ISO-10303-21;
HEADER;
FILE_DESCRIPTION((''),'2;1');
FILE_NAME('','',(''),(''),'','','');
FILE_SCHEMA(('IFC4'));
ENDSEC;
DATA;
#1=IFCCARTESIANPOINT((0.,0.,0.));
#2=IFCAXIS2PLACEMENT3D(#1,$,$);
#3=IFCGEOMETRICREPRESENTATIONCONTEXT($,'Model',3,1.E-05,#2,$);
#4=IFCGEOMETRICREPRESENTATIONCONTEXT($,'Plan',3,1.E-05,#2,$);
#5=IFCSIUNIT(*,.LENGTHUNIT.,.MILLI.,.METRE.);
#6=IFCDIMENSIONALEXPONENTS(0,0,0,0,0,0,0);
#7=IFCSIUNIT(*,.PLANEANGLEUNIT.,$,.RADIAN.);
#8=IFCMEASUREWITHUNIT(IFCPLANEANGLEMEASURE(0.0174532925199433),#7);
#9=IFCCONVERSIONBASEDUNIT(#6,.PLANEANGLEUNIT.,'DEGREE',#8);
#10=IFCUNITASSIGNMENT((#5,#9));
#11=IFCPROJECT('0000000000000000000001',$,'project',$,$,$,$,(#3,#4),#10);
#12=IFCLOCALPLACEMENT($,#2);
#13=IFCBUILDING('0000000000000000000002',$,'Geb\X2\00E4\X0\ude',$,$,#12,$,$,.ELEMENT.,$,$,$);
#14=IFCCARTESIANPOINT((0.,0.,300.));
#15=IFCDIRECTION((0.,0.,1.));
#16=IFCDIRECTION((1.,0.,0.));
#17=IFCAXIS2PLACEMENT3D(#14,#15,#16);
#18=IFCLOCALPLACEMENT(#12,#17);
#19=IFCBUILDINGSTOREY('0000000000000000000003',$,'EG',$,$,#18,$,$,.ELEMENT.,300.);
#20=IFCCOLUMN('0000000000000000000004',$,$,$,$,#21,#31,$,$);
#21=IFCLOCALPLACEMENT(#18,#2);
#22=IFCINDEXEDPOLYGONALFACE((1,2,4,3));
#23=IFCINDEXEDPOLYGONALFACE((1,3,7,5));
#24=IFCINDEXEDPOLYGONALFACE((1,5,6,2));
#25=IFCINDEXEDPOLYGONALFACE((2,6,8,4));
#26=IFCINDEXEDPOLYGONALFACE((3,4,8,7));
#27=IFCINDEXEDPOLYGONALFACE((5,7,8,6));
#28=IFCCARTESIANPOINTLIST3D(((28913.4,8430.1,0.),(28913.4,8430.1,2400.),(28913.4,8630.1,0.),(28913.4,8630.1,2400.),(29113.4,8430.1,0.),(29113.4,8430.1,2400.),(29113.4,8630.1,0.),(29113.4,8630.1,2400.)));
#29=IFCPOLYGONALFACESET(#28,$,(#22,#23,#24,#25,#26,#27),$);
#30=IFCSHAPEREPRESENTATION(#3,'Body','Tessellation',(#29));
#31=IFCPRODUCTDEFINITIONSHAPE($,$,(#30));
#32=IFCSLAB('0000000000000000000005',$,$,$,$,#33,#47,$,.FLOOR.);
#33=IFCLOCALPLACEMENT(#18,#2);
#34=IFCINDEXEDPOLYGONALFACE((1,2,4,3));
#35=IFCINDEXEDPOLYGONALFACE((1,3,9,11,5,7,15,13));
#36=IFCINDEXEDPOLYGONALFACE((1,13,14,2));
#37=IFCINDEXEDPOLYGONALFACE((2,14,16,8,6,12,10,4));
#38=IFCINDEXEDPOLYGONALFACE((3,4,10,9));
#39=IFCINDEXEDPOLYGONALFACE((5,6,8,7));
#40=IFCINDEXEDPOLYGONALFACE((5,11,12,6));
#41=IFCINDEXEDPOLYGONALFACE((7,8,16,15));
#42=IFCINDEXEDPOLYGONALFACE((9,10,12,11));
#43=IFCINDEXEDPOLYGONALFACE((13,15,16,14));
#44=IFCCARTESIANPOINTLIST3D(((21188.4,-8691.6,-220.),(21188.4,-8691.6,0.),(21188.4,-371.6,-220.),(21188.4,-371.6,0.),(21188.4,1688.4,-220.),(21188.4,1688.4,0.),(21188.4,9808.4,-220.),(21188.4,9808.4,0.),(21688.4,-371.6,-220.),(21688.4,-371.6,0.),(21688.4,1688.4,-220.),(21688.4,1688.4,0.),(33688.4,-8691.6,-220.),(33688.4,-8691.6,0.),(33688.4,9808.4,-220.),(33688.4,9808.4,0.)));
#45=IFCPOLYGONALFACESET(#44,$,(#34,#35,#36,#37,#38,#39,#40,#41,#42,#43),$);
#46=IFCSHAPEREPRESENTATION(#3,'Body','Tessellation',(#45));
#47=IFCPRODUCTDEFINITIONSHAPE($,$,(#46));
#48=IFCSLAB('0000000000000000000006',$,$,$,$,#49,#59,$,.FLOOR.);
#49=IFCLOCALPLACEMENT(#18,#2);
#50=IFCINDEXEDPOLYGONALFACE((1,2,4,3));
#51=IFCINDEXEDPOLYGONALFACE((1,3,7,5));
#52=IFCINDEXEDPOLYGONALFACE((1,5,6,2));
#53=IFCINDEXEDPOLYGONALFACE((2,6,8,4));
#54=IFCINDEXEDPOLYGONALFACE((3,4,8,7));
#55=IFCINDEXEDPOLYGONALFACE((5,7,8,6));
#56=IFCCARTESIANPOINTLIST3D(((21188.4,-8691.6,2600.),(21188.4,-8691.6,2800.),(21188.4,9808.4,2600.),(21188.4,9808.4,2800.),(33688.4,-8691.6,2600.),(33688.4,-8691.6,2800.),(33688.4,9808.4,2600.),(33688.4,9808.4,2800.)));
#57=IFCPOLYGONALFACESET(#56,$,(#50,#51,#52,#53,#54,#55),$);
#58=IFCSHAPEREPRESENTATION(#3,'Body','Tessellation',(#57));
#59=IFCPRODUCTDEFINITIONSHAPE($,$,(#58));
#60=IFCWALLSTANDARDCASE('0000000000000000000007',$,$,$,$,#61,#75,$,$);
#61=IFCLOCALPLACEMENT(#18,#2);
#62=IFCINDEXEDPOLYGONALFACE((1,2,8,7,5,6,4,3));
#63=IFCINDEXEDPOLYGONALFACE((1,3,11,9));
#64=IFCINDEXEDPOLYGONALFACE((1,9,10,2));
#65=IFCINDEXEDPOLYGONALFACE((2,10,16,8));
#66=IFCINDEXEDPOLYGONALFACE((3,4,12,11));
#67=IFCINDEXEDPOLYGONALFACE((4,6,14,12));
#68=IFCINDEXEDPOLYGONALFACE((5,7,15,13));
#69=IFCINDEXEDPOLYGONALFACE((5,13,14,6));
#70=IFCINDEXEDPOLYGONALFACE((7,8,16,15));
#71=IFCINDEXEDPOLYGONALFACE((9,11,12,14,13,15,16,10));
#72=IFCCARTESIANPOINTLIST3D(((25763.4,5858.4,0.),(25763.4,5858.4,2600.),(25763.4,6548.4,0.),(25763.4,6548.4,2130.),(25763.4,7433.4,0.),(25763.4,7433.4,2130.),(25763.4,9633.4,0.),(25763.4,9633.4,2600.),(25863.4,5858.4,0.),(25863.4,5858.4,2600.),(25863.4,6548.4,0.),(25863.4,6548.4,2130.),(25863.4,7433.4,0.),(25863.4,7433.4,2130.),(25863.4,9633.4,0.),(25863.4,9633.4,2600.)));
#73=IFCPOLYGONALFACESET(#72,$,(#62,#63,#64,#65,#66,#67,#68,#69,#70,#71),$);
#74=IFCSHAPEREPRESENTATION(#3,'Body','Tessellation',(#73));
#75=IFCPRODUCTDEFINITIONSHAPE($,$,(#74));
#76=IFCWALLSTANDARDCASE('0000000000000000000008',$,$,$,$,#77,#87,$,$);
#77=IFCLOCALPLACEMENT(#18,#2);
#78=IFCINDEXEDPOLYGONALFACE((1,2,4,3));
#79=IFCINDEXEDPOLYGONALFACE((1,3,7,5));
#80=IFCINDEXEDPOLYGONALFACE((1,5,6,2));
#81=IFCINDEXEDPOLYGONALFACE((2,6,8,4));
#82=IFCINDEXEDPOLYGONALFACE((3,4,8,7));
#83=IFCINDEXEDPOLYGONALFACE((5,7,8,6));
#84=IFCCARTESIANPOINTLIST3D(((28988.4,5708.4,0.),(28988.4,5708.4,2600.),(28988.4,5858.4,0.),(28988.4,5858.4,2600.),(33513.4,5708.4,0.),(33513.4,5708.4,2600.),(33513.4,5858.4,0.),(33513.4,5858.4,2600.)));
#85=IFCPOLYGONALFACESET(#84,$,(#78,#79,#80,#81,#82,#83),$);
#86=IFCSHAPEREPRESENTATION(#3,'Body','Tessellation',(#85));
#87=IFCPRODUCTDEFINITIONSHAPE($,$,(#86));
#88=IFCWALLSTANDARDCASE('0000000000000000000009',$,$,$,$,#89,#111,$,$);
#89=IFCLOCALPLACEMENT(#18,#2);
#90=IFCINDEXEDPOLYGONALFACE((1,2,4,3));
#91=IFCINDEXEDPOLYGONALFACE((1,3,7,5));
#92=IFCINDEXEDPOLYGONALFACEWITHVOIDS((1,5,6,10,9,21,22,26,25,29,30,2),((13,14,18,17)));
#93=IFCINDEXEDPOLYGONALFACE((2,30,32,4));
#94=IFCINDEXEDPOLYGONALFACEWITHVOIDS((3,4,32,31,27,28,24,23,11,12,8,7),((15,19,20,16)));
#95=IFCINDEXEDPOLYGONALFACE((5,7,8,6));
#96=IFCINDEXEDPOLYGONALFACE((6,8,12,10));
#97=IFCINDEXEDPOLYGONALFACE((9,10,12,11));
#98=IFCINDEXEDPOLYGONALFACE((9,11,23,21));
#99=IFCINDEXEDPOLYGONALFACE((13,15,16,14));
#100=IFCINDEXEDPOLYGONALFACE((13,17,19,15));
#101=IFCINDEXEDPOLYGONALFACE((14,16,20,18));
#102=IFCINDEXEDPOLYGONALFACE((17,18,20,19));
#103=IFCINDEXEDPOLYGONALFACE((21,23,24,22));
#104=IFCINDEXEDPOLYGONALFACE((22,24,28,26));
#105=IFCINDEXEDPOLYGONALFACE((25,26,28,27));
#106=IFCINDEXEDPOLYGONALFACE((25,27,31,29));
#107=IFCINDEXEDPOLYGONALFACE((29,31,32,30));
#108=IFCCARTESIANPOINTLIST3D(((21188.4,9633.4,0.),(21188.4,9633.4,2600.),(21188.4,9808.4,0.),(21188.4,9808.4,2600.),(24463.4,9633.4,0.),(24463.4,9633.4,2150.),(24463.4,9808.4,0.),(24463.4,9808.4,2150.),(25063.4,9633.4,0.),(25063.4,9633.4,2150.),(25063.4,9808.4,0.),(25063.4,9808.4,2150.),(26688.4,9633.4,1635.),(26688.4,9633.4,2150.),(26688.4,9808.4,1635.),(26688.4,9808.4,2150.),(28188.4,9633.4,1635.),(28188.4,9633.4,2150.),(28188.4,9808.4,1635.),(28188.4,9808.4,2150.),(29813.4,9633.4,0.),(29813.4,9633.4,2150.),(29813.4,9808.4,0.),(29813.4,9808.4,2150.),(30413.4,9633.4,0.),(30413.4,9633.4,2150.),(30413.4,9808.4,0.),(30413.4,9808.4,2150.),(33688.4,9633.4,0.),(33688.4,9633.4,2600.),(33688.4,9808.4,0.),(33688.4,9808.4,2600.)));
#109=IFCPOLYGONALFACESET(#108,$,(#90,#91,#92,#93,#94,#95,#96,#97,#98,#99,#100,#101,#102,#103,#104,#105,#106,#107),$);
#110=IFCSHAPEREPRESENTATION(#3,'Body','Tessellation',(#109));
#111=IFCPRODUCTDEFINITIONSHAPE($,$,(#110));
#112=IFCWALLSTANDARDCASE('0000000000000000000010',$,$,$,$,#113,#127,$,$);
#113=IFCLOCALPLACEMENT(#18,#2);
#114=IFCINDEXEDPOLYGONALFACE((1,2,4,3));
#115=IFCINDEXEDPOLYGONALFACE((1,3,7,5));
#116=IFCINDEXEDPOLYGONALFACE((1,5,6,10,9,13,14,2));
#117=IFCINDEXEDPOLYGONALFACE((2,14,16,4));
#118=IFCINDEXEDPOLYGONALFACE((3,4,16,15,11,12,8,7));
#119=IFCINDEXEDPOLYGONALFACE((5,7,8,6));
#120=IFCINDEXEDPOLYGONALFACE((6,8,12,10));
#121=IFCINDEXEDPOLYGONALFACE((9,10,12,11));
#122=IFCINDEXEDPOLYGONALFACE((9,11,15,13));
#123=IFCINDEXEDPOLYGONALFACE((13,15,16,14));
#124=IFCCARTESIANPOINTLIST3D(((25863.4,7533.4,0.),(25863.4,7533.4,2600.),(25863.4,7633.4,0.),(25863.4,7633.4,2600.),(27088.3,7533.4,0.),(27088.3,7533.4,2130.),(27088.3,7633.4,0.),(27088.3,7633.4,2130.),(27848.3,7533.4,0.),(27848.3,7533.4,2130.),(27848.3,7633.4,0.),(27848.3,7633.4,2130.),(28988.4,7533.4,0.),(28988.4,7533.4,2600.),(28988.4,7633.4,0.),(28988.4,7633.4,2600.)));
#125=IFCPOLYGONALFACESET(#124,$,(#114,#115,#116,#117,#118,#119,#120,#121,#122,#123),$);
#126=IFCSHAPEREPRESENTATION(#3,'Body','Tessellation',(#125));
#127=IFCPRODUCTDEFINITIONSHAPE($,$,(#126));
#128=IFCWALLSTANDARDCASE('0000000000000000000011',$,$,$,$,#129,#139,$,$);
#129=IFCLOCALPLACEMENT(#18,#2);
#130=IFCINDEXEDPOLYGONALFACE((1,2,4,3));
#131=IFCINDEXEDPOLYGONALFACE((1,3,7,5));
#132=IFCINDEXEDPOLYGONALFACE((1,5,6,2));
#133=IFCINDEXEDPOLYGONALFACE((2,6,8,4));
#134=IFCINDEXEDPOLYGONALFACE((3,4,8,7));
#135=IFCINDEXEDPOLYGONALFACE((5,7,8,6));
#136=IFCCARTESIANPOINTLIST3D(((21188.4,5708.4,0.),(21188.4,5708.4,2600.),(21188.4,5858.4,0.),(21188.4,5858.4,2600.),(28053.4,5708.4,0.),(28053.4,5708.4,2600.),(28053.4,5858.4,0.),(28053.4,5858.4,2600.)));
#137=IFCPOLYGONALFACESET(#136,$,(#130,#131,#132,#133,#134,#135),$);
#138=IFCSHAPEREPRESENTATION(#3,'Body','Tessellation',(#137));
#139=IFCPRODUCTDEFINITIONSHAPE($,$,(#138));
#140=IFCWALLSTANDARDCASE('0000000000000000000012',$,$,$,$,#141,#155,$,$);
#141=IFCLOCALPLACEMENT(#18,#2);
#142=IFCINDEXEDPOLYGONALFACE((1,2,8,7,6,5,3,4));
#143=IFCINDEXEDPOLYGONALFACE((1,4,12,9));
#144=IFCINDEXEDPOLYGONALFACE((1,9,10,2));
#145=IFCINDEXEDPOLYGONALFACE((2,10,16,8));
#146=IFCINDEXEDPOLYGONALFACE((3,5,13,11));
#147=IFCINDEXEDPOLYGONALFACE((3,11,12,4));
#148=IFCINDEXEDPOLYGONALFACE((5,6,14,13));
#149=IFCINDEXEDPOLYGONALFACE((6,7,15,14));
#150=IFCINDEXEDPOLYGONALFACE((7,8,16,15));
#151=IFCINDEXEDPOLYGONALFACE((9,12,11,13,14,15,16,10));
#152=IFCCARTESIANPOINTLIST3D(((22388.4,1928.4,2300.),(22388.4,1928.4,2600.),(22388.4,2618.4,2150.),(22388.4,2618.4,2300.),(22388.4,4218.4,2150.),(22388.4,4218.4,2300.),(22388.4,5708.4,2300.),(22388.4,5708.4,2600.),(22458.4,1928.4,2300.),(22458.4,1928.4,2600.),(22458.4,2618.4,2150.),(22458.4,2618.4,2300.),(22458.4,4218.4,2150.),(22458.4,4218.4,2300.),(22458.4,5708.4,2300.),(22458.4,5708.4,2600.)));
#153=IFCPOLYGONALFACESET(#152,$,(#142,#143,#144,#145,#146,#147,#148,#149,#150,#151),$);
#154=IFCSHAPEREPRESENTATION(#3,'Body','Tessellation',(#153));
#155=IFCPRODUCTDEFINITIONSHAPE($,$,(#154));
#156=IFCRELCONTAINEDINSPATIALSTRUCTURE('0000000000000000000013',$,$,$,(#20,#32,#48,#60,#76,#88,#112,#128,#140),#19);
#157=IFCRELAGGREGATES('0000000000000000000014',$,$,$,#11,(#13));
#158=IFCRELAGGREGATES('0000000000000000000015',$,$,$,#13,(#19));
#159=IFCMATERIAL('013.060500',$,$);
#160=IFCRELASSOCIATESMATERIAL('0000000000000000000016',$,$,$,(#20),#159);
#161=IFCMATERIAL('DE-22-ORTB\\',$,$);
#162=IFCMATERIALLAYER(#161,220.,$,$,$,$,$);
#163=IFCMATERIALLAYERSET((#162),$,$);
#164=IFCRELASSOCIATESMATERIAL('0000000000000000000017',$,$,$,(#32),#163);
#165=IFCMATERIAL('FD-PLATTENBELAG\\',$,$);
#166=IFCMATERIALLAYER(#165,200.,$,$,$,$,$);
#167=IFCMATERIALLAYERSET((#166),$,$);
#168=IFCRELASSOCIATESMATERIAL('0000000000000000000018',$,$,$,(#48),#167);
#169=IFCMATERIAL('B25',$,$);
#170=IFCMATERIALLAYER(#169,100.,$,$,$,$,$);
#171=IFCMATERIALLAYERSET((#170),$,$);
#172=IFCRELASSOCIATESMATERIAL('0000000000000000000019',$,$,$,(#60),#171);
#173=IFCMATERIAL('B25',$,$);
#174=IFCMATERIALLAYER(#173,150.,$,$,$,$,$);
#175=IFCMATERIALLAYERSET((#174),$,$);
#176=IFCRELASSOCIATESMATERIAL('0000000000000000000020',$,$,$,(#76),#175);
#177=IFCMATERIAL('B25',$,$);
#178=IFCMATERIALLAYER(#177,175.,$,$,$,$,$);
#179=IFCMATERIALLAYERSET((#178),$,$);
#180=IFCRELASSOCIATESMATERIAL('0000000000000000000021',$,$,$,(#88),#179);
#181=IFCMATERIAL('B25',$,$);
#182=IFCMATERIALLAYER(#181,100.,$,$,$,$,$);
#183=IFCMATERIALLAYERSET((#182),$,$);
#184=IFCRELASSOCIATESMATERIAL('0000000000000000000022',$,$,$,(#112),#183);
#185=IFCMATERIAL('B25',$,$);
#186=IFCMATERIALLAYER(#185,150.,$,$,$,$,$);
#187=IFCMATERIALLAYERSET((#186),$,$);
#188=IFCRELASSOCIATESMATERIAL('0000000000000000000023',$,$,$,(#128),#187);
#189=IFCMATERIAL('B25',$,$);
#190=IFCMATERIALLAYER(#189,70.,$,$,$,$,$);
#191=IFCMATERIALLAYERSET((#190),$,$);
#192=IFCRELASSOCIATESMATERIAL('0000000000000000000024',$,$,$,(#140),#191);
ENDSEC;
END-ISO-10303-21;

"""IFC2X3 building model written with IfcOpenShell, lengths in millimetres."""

from ifc_helpers import new_model, entity, si_unit, converted_unit, frame, frame_2d, origin, origin_with_axes, place, context, project, spatial, rectangle, extrude, material, layer, layer_set, layer_usage, element, save


model = new_model("IFC2X3")

# Units and contexts
model_context = context("Model", 3, precision=1e-05, world=origin())
plan_context = context("Plan", 3, precision=1e-05, world=origin())
ifc_project = project(units=[si_unit("LENGTHUNIT", "METRE", prefix="MILLI"), converted_unit("PLANEANGLEUNIT", "DEGREE", entity("IfcPlaneAngleMeasure", 0.0174532925199433), si_unit("PLANEANGLEUNIT", "RADIAN"), dimensions=[0, 0, 0, 0, 0, 0, 0])], contexts=[model_context, plan_context])

# Building, storey
building_placement = place(None, origin())
building = spatial("IfcBuilding", under=ifc_project, at=building_placement, Name="Gebäude", CompositionType="ELEMENT")
storey_placement = place(building_placement, frame((0.0, 0.0, 300.0), z_axis=(0.0, 0.0, 1.0), x_axis=(1.0, 0.0, 0.0)))
storey = spatial("IfcBuildingStorey", under=building, at=storey_placement, Name="EG", CompositionType="ELEMENT", Elevation=300.0)

# Column
ifc_material_1 = material(Name="013.060500")
column_placement = place(storey_placement, frame((28913.4, 8430.1, 0.0), z_axis=(0.0, 0.0, 1.0), x_axis=(1.0, 0.0, 0.0)))
element("IfcColumn", 1, at=column_placement, inside=storey, material=ifc_material_1, context=model_context, shape_type="SweptSolid", body=[
    extrude(rectangle(XDim=200.0, YDim=200.0, at=frame_2d((100.0, 100.0), x_axis=(1.0, 0.0))), origin_with_axes(), (0.0, 0.0, 1.0), 2400.0),
])

# Slab, opening
ifc_material_2 = material(Name="DE-22-ORTB\\")
ifc_layer_1 = layer(ifc_material_2, 220.0)
ifc_layer_set_1 = layer_set([ifc_layer_1])
ifc_layer_usage_1 = layer_usage(ifc_layer_set_1, "AXIS3", "POSITIVE", 0.0)
slab_1_placement = place(storey_placement, frame((21188.4, 9808.4, -220.0), z_axis=(0.0, 0.0, 1.0), x_axis=(1.0, 0.0, 0.0)))
slab_1 = element("IfcSlab", 2, at=slab_1_placement, inside=storey, material=ifc_layer_usage_1, PredefinedType="FLOOR", context=model_context, shape_type="SweptSolid", body=[
    extrude(rectangle(XDim=18500.0, YDim=12500.0, at=frame_2d((6250.0, -9250.0), x_axis=(0.0, -1.0))), origin_with_axes(), (0.0, 0.0, 1.0), 220.0),
])
opening_1_placement = place(slab_1_placement, frame((0.0, -8120.0, 0.0), z_axis=(0.0, 0.0, 1.0), x_axis=(1.0, 0.0, 0.0)))
element("IfcOpeningElement", 3, at=opening_1_placement, cuts=slab_1, ObjectType="Opening", context=model_context, shape_type="SweptSolid", body=[
    extrude(rectangle(XDim=2060.0, YDim=500.0, at=frame_2d((250.0, -1030.0), x_axis=(0.0, -1.0))), origin_with_axes(), (0.0, 0.0, 1.0), 220.0),
])

# Slab
ifc_material_3 = material(Name="FD-PLATTENBELAG\\")
ifc_layer_2 = layer(ifc_material_3, 200.0)
ifc_layer_set_2 = layer_set([ifc_layer_2])
ifc_layer_usage_2 = layer_usage(ifc_layer_set_2, "AXIS3", "POSITIVE", 0.0)
slab_2_placement = place(storey_placement, frame((21188.4, 9808.4, 2600.0), z_axis=(0.0, 0.0, 1.0), x_axis=(1.0, 0.0, 0.0)))
element("IfcSlab", 4, at=slab_2_placement, inside=storey, material=ifc_layer_usage_2, PredefinedType="FLOOR", context=model_context, shape_type="SweptSolid", body=[
    extrude(rectangle(XDim=18500.0, YDim=12500.0, at=frame_2d((6250.0, -9250.0), x_axis=(0.0, -1.0))), origin_with_axes(), (0.0, 0.0, 1.0), 200.0),
])

# Wall, opening
ifc_material_4 = material(Name="B25")
ifc_layer_3 = layer(ifc_material_4, 100.0)
ifc_layer_set_3 = layer_set([ifc_layer_3])
ifc_layer_usage_3 = layer_usage(ifc_layer_set_3, "AXIS2", "POSITIVE", 0.0)
wall_1_placement = place(storey_placement, frame((25763.4, 9633.4, 0.0), z_axis=(0.0, 0.0, 1.0), x_axis=(0.0, -1.0, 0.0)))
wall_1 = element("IfcWallStandardCase", 5, at=wall_1_placement, inside=storey, material=ifc_layer_usage_3, context=model_context, shape_type="SweptSolid", body=[
    extrude(rectangle(XDim=3775.0, YDim=100.0, at=frame_2d((1887.5, 50.0), x_axis=(1.0, 0.0))), origin_with_axes(), (0.0, 0.0, 1.0), 2600.0),
])
opening_2_placement = place(wall_1_placement, frame((2200.0, 0.0, 0.0), z_axis=(0.0, 1.0, 0.0), x_axis=(0.0, 0.0, 1.0)))
element("IfcOpeningElement", 6, at=opening_2_placement, cuts=wall_1, ObjectType="Opening", context=model_context, shape_type="SweptSolid", body=[
    extrude(rectangle(XDim=2130.0, YDim=885.0, at=frame_2d((1065.0, 442.5), x_axis=(1.0, 0.0))), origin_with_axes(), (0.0, 0.0, 1.0), 100.0),
])

# Wall
ifc_material_5 = material(Name="B25")
ifc_layer_4 = layer(ifc_material_5, 150.0)
ifc_layer_set_4 = layer_set([ifc_layer_4])
ifc_layer_usage_4 = layer_usage(ifc_layer_set_4, "AXIS2", "POSITIVE", 0.0)
wall_2_placement = place(storey_placement, frame((28988.4, 5708.4, 0.0), z_axis=(0.0, 0.0, 1.0), x_axis=(1.0, 0.0, 0.0)))
element("IfcWallStandardCase", 7, at=wall_2_placement, inside=storey, material=ifc_layer_usage_4, context=model_context, shape_type="SweptSolid", body=[
    extrude(rectangle(XDim=4525.0, YDim=150.0, at=frame_2d((2262.5, 75.0), x_axis=(1.0, 0.0))), origin_with_axes(), (0.0, 0.0, 1.0), 2600.0),
])

# Wall, openings
ifc_material_6 = material(Name="B25")
ifc_layer_5 = layer(ifc_material_6, 175.0)
ifc_layer_set_5 = layer_set([ifc_layer_5])
ifc_layer_usage_5 = layer_usage(ifc_layer_set_5, "AXIS2", "POSITIVE", 0.0)
wall_3_placement = place(storey_placement, frame((33688.4, 9808.4, 0.0), z_axis=(0.0, 0.0, 1.0), x_axis=(-1.0, 0.0, 0.0)))
wall_3 = element("IfcWallStandardCase", 8, at=wall_3_placement, inside=storey, material=ifc_layer_usage_5, context=model_context, shape_type="SweptSolid", body=[
    extrude(rectangle(XDim=12500.0, YDim=175.0, at=frame_2d((6250.0, 87.5), x_axis=(1.0, 0.0))), origin_with_axes(), (0.0, 0.0, 1.0), 2600.0),
])
opening_3_placement = place(wall_3_placement, frame((3275.0, 0.0, 0.0), z_axis=(0.0, 1.0, 0.0), x_axis=(0.0, 0.0, 1.0)))
element("IfcOpeningElement", 9, at=opening_3_placement, cuts=wall_3, ObjectType="Opening", context=model_context, shape_type="SweptSolid", body=[
    extrude(rectangle(XDim=2150.0, YDim=600.0, at=frame_2d((1075.0, 300.0), x_axis=(1.0, 0.0))), origin_with_axes(), (0.0, 0.0, 1.0), 175.0),
])
opening_4_placement = place(wall_3_placement, frame((5500.0, 0.0, 1635.0), z_axis=(0.0, 1.0, 0.0), x_axis=(0.0, 0.0, 1.0)))
element("IfcOpeningElement", 10, at=opening_4_placement, cuts=wall_3, ObjectType="Opening", context=model_context, shape_type="SweptSolid", body=[
    extrude(rectangle(XDim=515.0, YDim=1500.0, at=frame_2d((257.5, 750.0), x_axis=(1.0, 0.0))), origin_with_axes(), (0.0, 0.0, 1.0), 175.0),
])
opening_5_placement = place(wall_3_placement, frame((8625.0, 0.0, 0.0), z_axis=(0.0, 1.0, 0.0), x_axis=(0.0, 0.0, 1.0)))
element("IfcOpeningElement", 11, at=opening_5_placement, cuts=wall_3, ObjectType="Opening", context=model_context, shape_type="SweptSolid", body=[
    extrude(rectangle(XDim=2150.0, YDim=600.0, at=frame_2d((1075.0, 300.0), x_axis=(1.0, 0.0))), origin_with_axes(), (0.0, 0.0, 1.0), 175.0),
])

# Wall, opening
ifc_material_7 = material(Name="B25")
ifc_layer_6 = layer(ifc_material_7, 100.0)
ifc_layer_set_6 = layer_set([ifc_layer_6])
ifc_layer_usage_6 = layer_usage(ifc_layer_set_6, "AXIS2", "POSITIVE", 0.0)
wall_4_placement = place(storey_placement, frame((25863.4, 7533.4, 0.0), z_axis=(0.0, 0.0, 1.0), x_axis=(1.0, 0.0, 0.0)))
wall_4 = element("IfcWallStandardCase", 12, at=wall_4_placement, inside=storey, material=ifc_layer_usage_6, context=model_context, shape_type="SweptSolid", body=[
    extrude(rectangle(XDim=3125.0, YDim=100.0, at=frame_2d((1562.5, 50.0), x_axis=(1.0, 0.0))), origin_with_axes(), (0.0, 0.0, 1.0), 2600.0),
])
opening_6_placement = place(wall_4_placement, frame((1225.0, 0.0, 0.0), z_axis=(0.0, 1.0, 0.0), x_axis=(0.0, 0.0, 1.0)))
element("IfcOpeningElement", 13, at=opening_6_placement, cuts=wall_4, ObjectType="Opening", context=model_context, shape_type="SweptSolid", body=[
    extrude(rectangle(XDim=2130.0, YDim=760.0, at=frame_2d((1065.0, 380.0), x_axis=(1.0, 0.0))), origin_with_axes(), (0.0, 0.0, 1.0), 100.0),
])

# Wall
ifc_material_8 = material(Name="B25")
ifc_layer_7 = layer(ifc_material_8, 150.0)
ifc_layer_set_7 = layer_set([ifc_layer_7])
ifc_layer_usage_7 = layer_usage(ifc_layer_set_7, "AXIS2", "POSITIVE", 0.0)
wall_5_placement = place(storey_placement, frame((21188.4, 5708.4, 0.0), z_axis=(0.0, 0.0, 1.0), x_axis=(1.0, 0.0, 0.0)))
element("IfcWallStandardCase", 14, at=wall_5_placement, inside=storey, material=ifc_layer_usage_7, context=model_context, shape_type="SweptSolid", body=[
    extrude(rectangle(XDim=6865.0, YDim=150.0, at=frame_2d((3432.5, 75.0), x_axis=(1.0, 0.0))), origin_with_axes(), (0.0, 0.0, 1.0), 2600.0),
])

# Wall, openings
ifc_material_9 = material(Name="B25")
ifc_layer_8 = layer(ifc_material_9, 70.0)
ifc_layer_set_8 = layer_set([ifc_layer_8])
ifc_layer_usage_8 = layer_usage(ifc_layer_set_8, "AXIS2", "POSITIVE", 0.0)
wall_6_placement = place(storey_placement, frame((22458.4, 1928.4, 0.0), z_axis=(0.0, 0.0, 1.0), x_axis=(0.0, 1.0, 0.0)))
wall_6 = element("IfcWallStandardCase", 15, at=wall_6_placement, inside=storey, material=ifc_layer_usage_8, context=model_context, shape_type="SweptSolid", body=[
    extrude(rectangle(XDim=3780.0, YDim=70.0, at=frame_2d((1890.0, 35.0), x_axis=(1.0, 0.0))), origin_with_axes(), (0.0, 0.0, 1.0), 2600.0),
])
opening_7_placement = place(wall_6_placement, frame((2290.0, 0.0, 0.0), z_axis=(0.0, 1.0, 0.0), x_axis=(0.0, 0.0, 1.0)))
element("IfcOpeningElement", 16, at=opening_7_placement, cuts=wall_6, ObjectType="Opening", context=model_context, shape_type="SweptSolid", body=[
    extrude(rectangle(XDim=2300.0, YDim=1490.0, at=frame_2d((1150.0, 745.0), x_axis=(1.0, 0.0))), origin_with_axes(), (0.0, 0.0, 1.0), 70.0),
])
opening_8_placement = place(wall_6_placement, frame((0.0, 0.0, 0.0), z_axis=(0.0, 1.0, 0.0), x_axis=(0.0, 0.0, 1.0)))
element("IfcOpeningElement", 17, at=opening_8_placement, cuts=wall_6, ObjectType="Opening", context=model_context, shape_type="SweptSolid", body=[
    extrude(rectangle(XDim=2300.0, YDim=690.0, at=frame_2d((1150.0, 345.0), x_axis=(1.0, 0.0))), origin_with_axes(), (0.0, 0.0, 1.0), 70.0),
])
opening_9_placement = place(wall_6_placement, frame((690.0, 0.0, 0.0), z_axis=(0.0, 1.0, 0.0), x_axis=(0.0, 0.0, 1.0)))
element("IfcOpeningElement", 18, at=opening_9_placement, cuts=wall_6, ObjectType="Opening", context=model_context, shape_type="SweptSolid", body=[
    extrude(rectangle(XDim=2150.0, YDim=1600.0, at=frame_2d((1075.0, 800.0), x_axis=(1.0, 0.0))), origin_with_axes(), (0.0, 0.0, 1.0), 70.0),
])

save(model, "model.ifc")
